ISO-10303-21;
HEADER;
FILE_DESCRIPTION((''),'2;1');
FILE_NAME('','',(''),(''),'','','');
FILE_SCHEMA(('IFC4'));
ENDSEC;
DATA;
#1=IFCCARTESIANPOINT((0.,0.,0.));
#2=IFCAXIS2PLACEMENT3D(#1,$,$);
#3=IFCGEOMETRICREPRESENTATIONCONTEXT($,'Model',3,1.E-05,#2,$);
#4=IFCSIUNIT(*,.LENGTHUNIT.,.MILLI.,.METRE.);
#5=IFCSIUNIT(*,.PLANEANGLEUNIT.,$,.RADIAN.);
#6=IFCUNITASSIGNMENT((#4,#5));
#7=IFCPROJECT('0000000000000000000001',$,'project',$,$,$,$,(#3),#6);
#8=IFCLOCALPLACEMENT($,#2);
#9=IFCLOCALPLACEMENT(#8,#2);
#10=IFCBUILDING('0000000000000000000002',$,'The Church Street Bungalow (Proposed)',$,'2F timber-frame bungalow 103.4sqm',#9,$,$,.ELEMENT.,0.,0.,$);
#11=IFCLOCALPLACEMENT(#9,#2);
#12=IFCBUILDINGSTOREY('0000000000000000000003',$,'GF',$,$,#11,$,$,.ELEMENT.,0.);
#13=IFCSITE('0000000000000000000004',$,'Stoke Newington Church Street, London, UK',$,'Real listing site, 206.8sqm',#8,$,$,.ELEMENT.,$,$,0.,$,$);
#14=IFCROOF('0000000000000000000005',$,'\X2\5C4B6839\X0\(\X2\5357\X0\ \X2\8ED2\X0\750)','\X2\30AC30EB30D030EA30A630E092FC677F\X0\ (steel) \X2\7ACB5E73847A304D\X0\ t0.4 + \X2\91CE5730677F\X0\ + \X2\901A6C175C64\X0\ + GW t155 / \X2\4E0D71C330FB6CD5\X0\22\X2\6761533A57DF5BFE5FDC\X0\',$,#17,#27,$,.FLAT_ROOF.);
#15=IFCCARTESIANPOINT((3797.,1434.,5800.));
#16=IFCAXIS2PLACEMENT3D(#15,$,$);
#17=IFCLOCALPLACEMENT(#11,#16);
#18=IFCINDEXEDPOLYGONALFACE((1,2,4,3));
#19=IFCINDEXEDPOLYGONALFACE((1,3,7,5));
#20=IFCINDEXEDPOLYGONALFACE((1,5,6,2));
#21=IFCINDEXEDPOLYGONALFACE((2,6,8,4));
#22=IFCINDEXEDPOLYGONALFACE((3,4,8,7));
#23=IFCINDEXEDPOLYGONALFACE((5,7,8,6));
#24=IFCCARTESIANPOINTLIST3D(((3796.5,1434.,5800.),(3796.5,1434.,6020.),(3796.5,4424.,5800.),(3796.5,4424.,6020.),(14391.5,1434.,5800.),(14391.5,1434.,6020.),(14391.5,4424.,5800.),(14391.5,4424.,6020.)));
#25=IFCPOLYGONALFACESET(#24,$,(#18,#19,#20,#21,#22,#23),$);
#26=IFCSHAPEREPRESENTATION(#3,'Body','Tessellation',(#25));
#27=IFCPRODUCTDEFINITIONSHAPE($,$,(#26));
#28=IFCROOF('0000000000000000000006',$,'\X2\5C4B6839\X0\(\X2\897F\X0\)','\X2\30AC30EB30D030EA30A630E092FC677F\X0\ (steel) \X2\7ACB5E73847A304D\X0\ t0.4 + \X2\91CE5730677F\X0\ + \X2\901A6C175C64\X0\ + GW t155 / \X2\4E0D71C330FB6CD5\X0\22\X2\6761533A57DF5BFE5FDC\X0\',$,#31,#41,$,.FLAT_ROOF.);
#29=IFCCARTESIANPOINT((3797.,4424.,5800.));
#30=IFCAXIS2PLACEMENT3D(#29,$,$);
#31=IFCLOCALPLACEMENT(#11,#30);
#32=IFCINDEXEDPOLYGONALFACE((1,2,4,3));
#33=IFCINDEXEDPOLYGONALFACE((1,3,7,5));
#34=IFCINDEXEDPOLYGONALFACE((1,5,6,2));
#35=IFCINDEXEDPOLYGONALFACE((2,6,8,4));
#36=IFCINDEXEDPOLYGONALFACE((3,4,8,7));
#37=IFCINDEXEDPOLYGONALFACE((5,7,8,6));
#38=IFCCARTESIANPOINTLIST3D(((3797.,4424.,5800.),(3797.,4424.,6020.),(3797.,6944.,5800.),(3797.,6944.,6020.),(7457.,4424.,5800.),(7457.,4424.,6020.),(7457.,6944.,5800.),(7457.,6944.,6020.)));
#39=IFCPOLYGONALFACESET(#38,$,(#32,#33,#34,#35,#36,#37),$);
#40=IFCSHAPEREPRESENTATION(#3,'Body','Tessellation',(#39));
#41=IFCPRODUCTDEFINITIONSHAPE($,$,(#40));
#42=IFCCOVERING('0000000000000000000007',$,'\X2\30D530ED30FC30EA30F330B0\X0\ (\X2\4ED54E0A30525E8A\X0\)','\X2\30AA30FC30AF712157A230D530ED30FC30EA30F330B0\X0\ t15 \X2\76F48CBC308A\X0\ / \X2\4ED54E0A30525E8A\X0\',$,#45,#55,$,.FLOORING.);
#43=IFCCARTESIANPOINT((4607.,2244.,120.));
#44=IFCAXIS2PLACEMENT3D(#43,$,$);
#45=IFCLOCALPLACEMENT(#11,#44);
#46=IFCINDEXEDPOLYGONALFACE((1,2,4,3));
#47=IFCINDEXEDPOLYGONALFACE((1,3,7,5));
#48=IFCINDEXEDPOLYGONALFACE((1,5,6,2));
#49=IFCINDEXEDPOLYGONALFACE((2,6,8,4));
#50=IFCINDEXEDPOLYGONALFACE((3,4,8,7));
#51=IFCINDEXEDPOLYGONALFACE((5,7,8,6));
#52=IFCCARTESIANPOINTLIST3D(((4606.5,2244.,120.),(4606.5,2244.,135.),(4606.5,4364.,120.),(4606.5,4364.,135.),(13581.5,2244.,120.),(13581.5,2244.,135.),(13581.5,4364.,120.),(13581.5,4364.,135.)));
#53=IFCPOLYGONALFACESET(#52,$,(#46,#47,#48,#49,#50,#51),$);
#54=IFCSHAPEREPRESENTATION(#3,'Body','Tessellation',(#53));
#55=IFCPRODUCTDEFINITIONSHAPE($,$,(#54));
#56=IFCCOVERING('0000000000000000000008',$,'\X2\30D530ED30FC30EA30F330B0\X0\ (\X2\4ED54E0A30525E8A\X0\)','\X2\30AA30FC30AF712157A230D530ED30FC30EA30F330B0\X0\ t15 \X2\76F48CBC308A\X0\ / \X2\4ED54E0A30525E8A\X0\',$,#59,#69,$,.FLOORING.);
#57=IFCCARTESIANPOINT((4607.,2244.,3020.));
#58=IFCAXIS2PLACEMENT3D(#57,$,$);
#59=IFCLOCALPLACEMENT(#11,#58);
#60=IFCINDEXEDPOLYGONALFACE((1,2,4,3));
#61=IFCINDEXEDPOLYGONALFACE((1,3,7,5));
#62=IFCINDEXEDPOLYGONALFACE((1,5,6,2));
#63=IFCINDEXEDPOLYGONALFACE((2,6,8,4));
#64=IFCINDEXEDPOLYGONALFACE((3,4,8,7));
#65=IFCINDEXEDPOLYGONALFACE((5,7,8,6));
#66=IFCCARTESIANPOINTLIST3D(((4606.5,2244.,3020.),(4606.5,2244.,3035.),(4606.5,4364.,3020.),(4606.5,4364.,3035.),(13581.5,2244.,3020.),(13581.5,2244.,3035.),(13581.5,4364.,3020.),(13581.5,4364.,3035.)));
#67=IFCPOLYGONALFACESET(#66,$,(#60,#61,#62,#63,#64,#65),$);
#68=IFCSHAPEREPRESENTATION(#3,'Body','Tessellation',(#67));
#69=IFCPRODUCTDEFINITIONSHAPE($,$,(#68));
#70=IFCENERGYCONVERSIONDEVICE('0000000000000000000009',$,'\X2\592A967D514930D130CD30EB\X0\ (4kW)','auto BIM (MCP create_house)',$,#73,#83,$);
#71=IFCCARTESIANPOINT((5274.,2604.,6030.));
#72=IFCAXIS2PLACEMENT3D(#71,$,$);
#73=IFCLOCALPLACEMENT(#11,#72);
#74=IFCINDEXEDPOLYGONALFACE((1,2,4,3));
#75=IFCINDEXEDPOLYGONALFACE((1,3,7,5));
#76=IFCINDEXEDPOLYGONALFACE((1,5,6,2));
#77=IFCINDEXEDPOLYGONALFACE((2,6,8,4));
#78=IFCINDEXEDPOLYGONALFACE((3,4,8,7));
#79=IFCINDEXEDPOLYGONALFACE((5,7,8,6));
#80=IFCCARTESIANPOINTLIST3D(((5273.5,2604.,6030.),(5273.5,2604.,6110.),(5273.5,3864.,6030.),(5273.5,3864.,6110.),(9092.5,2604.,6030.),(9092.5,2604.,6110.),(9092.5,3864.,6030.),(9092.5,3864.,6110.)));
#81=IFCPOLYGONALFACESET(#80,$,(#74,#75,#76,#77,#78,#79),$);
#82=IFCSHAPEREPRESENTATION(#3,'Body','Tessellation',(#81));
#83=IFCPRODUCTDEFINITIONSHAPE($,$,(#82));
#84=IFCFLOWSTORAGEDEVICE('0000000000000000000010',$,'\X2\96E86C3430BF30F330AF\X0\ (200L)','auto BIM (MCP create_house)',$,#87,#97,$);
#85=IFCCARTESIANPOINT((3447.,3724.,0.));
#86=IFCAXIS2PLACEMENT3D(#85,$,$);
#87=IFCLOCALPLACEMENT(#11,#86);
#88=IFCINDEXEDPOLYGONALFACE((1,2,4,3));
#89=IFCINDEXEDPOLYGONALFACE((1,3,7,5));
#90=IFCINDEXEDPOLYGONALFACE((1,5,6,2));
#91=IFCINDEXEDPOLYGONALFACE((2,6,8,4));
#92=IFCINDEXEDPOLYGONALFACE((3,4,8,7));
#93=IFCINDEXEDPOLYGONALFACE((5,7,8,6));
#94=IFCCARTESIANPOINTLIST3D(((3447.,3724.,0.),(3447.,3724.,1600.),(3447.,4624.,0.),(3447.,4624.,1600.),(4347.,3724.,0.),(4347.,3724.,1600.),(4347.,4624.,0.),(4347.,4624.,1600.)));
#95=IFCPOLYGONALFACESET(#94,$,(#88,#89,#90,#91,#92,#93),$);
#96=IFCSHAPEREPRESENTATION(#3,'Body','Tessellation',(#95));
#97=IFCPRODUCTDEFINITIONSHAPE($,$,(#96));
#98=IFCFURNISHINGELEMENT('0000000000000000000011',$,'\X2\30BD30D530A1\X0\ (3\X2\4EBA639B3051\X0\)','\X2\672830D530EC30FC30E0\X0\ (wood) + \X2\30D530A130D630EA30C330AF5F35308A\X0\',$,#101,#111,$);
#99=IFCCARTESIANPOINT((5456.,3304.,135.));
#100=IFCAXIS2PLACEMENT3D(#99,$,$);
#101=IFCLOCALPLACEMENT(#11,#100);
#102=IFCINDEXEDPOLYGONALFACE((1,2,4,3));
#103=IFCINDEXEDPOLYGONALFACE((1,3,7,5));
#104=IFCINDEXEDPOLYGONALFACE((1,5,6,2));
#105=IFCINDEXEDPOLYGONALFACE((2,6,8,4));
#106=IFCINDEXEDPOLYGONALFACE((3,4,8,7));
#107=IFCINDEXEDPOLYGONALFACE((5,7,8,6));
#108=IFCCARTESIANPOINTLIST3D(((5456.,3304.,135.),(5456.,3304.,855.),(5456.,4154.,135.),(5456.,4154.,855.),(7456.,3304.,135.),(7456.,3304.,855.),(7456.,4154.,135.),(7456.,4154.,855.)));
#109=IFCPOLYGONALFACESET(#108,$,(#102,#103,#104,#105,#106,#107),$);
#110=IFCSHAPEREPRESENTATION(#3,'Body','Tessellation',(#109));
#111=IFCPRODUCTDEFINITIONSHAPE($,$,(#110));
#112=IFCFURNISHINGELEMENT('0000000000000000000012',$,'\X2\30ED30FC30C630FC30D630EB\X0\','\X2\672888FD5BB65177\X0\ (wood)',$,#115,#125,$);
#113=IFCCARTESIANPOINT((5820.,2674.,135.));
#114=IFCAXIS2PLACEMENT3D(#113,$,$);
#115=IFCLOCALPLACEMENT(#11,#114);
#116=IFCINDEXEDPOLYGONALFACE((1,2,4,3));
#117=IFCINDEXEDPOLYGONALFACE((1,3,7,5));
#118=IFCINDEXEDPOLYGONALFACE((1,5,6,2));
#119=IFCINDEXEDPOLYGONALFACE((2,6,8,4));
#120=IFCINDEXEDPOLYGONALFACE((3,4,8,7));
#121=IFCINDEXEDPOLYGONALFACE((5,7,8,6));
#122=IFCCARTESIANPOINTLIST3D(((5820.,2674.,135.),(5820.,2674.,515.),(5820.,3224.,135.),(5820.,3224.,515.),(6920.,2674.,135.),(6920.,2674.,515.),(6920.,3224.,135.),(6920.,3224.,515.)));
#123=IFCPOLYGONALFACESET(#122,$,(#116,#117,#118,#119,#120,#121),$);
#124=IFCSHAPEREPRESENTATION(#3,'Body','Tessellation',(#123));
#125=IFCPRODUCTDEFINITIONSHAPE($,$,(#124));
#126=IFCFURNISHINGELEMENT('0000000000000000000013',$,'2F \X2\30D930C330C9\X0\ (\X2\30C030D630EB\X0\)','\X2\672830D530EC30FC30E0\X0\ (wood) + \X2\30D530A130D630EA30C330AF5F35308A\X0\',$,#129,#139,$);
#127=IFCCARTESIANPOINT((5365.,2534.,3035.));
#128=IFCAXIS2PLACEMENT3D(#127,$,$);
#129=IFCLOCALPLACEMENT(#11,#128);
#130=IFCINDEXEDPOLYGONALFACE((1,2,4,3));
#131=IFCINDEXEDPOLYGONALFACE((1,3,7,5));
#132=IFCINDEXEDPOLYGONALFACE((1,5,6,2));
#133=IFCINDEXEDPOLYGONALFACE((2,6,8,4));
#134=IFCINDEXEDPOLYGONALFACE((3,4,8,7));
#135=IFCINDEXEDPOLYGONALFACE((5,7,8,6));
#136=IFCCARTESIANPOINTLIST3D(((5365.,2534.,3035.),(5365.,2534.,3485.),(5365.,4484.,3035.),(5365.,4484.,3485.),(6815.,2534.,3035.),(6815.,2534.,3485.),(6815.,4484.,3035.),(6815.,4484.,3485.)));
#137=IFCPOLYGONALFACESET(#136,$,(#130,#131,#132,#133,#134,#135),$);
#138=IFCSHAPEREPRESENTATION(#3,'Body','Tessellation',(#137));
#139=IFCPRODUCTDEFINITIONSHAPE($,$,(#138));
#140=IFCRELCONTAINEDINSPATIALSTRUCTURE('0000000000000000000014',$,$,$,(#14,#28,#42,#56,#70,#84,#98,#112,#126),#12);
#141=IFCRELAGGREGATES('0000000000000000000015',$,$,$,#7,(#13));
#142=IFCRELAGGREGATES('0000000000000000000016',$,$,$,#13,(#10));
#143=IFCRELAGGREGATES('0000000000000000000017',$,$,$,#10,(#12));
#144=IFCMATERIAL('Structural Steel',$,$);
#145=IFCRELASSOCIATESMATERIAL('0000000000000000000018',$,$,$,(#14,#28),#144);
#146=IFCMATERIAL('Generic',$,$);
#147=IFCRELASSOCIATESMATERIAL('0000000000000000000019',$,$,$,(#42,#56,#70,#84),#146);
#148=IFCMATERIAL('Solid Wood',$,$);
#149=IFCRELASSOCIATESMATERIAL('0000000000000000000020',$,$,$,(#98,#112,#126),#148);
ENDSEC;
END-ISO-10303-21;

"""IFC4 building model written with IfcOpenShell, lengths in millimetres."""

from ifc_helpers import new_model, si_unit, frame, frame_2d, origin, place, context, project, spatial, rectangle, extrude, material, element, save


model = new_model("IFC4")

# Units and contexts
model_context = context("Model", 3, precision=1e-05, world=origin())
ifc_project = project(units=[si_unit("LENGTHUNIT", "METRE", prefix="MILLI"), si_unit("PLANEANGLEUNIT", "RADIAN")], contexts=[model_context])

# Site, building, storey
site_placement = place(None, origin())
site = spatial("IfcSite", under=ifc_project, at=site_placement, Name="Stoke Newington Church Street, London, UK", ObjectType="Real listing site, 206.8sqm", CompositionType="ELEMENT", RefElevation=0.0)
building_placement = place(site_placement, origin())
building = spatial("IfcBuilding", under=site, at=building_placement, Name="The Church Street Bungalow (Proposed)", ObjectType="2F timber-frame bungalow 103.4sqm", CompositionType="ELEMENT", ElevationOfRefHeight=0.0, ElevationOfTerrain=0.0)
storey_placement = place(building_placement, origin())
storey = spatial("IfcBuildingStorey", under=building, at=storey_placement, Name="GF", CompositionType="ELEMENT", Elevation=0.0)

# Shared definitions
ifc_material_1 = material(Name="Solid Wood")

# Roofs
ifc_material_2 = material(Name="Structural Steel")
roof_1_placement = place(storey_placement, frame((3797.0, 1434.0, 5800.0)))
element("IfcRoof", 1, at=roof_1_placement, inside=storey, material=ifc_material_2, Name="屋根(南 軒750)", Description="ガルバリウム鋼板 (steel) 立平葺き t0.4 + 野地板 + 通気層 + GW t155 / 不燃・法22条区域対応", PredefinedType="FLAT_ROOF", context=model_context, shape_type="SweptSolid", body=[
    extrude(rectangle(XDim=10595.0, YDim=2990.0, at=frame_2d((5297.0, 1495.0))), frame((3797.0, 1434.0, 5800.0)), (0.0, 0.0, 1.0), 220.0),
])
roof_2_placement = place(storey_placement, frame((3797.0, 4424.0, 5800.0)))
element("IfcRoof", 2, at=roof_2_placement, inside=storey, material=ifc_material_2, Name="屋根(西)", Description="ガルバリウム鋼板 (steel) 立平葺き t0.4 + 野地板 + 通気層 + GW t155 / 不燃・法22条区域対応", PredefinedType="FLAT_ROOF", context=model_context, shape_type="SweptSolid", body=[
    extrude(rectangle(XDim=3660.0, YDim=2520.0, at=frame_2d((1830.0, 1260.0))), frame((3797.0, 4424.0, 5800.0)), (0.0, 0.0, 1.0), 220.0),
])

# Coverings
ifc_material_3 = material(Name="Generic")
covering_1_placement = place(storey_placement, frame((4607.0, 2244.0, 120.0)))
element("IfcCovering", 3, at=covering_1_placement, inside=storey, material=ifc_material_3, Name="フローリング (仕上げ床)", Description="オーク無垢フローリング t15 直貼り / 仕上げ床", PredefinedType="FLOORING", context=model_context, shape_type="SweptSolid", body=[
    extrude(rectangle(XDim=8975.0, YDim=2120.0, at=frame_2d((4487.0, 1060.0))), frame((4607.0, 2244.0, 120.0)), (0.0, 0.0, 1.0), 15.0),
])
covering_2_placement = place(storey_placement, frame((4607.0, 2244.0, 3020.0)))
element("IfcCovering", 4, at=covering_2_placement, inside=storey, material=ifc_material_3, Name="フローリング (仕上げ床)", Description="オーク無垢フローリング t15 直貼り / 仕上げ床", PredefinedType="FLOORING", context=model_context, shape_type="SweptSolid", body=[
    extrude(rectangle(XDim=8975.0, YDim=2120.0, at=frame_2d((4487.0, 1060.0))), frame((4607.0, 2244.0, 3020.0)), (0.0, 0.0, 1.0), 15.0),
])

# Energy conversion device
energy_conversion_device_placement = place(storey_placement, frame((5274.0, 2604.0, 6030.0)))
element("IfcEnergyConversionDevice", 5, at=energy_conversion_device_placement, inside=storey, material=ifc_material_3, Name="太陽光パネル (4kW)", Description="auto BIM (MCP create_house)", context=model_context, shape_type="SweptSolid", body=[
    extrude(rectangle(XDim=3819.0, YDim=1260.0, at=frame_2d((1909.0, 630.0))), frame((5274.0, 2604.0, 6030.0)), (0.0, 0.0, 1.0), 80.0),
])

# Flow storage device
flow_storage_device_placement = place(storey_placement, frame((3447.0, 3724.0, 0.0)))
element("IfcFlowStorageDevice", 6, at=flow_storage_device_placement, inside=storey, material=ifc_material_3, Name="雨水タンク (200L)", Description="auto BIM (MCP create_house)", context=model_context, shape_type="SweptSolid", body=[
    extrude(rectangle(XDim=900.0, YDim=900.0, at=frame_2d((450.0, 450.0))), frame((3447.0, 3724.0, 0.0)), (0.0, 0.0, 1.0), 1600.0),
])

# Furnishing elements
furnishing_1_placement = place(storey_placement, frame((5456.0, 3304.0, 135.0)))
element("IfcFurnishingElement", 7, at=furnishing_1_placement, inside=storey, material=ifc_material_1, Name="ソファ (3人掛け)", Description="木フレーム (wood) + ファブリック張り", context=model_context, shape_type="SweptSolid", body=[
    extrude(rectangle(XDim=2000.0, YDim=850.0, at=frame_2d((1000.0, 425.0))), frame((5456.0, 3304.0, 135.0)), (0.0, 0.0, 1.0), 720.0),
])
furnishing_2_placement = place(storey_placement, frame((5820.0, 2674.0, 135.0)))
element("IfcFurnishingElement", 8, at=furnishing_2_placement, inside=storey, material=ifc_material_1, Name="ローテーブル", Description="木製家具 (wood)", context=model_context, shape_type="SweptSolid", body=[
    extrude(rectangle(XDim=1100.0, YDim=550.0, at=frame_2d((550.0, 275.0))), frame((5820.0, 2674.0, 135.0)), (0.0, 0.0, 1.0), 380.0),
])
furnishing_3_placement = place(storey_placement, frame((5365.0, 2534.0, 3035.0)))
element("IfcFurnishingElement", 9, at=furnishing_3_placement, inside=storey, material=ifc_material_1, Name="2F ベッド (ダブル)", Description="木フレーム (wood) + ファブリック張り", context=model_context, shape_type="SweptSolid", body=[
    extrude(rectangle(XDim=1450.0, YDim=1950.0, at=frame_2d((725.0, 975.0))), frame((5365.0, 2534.0, 3035.0)), (0.0, 0.0, 1.0), 450.0),
])

save(model, "model.ifc")
